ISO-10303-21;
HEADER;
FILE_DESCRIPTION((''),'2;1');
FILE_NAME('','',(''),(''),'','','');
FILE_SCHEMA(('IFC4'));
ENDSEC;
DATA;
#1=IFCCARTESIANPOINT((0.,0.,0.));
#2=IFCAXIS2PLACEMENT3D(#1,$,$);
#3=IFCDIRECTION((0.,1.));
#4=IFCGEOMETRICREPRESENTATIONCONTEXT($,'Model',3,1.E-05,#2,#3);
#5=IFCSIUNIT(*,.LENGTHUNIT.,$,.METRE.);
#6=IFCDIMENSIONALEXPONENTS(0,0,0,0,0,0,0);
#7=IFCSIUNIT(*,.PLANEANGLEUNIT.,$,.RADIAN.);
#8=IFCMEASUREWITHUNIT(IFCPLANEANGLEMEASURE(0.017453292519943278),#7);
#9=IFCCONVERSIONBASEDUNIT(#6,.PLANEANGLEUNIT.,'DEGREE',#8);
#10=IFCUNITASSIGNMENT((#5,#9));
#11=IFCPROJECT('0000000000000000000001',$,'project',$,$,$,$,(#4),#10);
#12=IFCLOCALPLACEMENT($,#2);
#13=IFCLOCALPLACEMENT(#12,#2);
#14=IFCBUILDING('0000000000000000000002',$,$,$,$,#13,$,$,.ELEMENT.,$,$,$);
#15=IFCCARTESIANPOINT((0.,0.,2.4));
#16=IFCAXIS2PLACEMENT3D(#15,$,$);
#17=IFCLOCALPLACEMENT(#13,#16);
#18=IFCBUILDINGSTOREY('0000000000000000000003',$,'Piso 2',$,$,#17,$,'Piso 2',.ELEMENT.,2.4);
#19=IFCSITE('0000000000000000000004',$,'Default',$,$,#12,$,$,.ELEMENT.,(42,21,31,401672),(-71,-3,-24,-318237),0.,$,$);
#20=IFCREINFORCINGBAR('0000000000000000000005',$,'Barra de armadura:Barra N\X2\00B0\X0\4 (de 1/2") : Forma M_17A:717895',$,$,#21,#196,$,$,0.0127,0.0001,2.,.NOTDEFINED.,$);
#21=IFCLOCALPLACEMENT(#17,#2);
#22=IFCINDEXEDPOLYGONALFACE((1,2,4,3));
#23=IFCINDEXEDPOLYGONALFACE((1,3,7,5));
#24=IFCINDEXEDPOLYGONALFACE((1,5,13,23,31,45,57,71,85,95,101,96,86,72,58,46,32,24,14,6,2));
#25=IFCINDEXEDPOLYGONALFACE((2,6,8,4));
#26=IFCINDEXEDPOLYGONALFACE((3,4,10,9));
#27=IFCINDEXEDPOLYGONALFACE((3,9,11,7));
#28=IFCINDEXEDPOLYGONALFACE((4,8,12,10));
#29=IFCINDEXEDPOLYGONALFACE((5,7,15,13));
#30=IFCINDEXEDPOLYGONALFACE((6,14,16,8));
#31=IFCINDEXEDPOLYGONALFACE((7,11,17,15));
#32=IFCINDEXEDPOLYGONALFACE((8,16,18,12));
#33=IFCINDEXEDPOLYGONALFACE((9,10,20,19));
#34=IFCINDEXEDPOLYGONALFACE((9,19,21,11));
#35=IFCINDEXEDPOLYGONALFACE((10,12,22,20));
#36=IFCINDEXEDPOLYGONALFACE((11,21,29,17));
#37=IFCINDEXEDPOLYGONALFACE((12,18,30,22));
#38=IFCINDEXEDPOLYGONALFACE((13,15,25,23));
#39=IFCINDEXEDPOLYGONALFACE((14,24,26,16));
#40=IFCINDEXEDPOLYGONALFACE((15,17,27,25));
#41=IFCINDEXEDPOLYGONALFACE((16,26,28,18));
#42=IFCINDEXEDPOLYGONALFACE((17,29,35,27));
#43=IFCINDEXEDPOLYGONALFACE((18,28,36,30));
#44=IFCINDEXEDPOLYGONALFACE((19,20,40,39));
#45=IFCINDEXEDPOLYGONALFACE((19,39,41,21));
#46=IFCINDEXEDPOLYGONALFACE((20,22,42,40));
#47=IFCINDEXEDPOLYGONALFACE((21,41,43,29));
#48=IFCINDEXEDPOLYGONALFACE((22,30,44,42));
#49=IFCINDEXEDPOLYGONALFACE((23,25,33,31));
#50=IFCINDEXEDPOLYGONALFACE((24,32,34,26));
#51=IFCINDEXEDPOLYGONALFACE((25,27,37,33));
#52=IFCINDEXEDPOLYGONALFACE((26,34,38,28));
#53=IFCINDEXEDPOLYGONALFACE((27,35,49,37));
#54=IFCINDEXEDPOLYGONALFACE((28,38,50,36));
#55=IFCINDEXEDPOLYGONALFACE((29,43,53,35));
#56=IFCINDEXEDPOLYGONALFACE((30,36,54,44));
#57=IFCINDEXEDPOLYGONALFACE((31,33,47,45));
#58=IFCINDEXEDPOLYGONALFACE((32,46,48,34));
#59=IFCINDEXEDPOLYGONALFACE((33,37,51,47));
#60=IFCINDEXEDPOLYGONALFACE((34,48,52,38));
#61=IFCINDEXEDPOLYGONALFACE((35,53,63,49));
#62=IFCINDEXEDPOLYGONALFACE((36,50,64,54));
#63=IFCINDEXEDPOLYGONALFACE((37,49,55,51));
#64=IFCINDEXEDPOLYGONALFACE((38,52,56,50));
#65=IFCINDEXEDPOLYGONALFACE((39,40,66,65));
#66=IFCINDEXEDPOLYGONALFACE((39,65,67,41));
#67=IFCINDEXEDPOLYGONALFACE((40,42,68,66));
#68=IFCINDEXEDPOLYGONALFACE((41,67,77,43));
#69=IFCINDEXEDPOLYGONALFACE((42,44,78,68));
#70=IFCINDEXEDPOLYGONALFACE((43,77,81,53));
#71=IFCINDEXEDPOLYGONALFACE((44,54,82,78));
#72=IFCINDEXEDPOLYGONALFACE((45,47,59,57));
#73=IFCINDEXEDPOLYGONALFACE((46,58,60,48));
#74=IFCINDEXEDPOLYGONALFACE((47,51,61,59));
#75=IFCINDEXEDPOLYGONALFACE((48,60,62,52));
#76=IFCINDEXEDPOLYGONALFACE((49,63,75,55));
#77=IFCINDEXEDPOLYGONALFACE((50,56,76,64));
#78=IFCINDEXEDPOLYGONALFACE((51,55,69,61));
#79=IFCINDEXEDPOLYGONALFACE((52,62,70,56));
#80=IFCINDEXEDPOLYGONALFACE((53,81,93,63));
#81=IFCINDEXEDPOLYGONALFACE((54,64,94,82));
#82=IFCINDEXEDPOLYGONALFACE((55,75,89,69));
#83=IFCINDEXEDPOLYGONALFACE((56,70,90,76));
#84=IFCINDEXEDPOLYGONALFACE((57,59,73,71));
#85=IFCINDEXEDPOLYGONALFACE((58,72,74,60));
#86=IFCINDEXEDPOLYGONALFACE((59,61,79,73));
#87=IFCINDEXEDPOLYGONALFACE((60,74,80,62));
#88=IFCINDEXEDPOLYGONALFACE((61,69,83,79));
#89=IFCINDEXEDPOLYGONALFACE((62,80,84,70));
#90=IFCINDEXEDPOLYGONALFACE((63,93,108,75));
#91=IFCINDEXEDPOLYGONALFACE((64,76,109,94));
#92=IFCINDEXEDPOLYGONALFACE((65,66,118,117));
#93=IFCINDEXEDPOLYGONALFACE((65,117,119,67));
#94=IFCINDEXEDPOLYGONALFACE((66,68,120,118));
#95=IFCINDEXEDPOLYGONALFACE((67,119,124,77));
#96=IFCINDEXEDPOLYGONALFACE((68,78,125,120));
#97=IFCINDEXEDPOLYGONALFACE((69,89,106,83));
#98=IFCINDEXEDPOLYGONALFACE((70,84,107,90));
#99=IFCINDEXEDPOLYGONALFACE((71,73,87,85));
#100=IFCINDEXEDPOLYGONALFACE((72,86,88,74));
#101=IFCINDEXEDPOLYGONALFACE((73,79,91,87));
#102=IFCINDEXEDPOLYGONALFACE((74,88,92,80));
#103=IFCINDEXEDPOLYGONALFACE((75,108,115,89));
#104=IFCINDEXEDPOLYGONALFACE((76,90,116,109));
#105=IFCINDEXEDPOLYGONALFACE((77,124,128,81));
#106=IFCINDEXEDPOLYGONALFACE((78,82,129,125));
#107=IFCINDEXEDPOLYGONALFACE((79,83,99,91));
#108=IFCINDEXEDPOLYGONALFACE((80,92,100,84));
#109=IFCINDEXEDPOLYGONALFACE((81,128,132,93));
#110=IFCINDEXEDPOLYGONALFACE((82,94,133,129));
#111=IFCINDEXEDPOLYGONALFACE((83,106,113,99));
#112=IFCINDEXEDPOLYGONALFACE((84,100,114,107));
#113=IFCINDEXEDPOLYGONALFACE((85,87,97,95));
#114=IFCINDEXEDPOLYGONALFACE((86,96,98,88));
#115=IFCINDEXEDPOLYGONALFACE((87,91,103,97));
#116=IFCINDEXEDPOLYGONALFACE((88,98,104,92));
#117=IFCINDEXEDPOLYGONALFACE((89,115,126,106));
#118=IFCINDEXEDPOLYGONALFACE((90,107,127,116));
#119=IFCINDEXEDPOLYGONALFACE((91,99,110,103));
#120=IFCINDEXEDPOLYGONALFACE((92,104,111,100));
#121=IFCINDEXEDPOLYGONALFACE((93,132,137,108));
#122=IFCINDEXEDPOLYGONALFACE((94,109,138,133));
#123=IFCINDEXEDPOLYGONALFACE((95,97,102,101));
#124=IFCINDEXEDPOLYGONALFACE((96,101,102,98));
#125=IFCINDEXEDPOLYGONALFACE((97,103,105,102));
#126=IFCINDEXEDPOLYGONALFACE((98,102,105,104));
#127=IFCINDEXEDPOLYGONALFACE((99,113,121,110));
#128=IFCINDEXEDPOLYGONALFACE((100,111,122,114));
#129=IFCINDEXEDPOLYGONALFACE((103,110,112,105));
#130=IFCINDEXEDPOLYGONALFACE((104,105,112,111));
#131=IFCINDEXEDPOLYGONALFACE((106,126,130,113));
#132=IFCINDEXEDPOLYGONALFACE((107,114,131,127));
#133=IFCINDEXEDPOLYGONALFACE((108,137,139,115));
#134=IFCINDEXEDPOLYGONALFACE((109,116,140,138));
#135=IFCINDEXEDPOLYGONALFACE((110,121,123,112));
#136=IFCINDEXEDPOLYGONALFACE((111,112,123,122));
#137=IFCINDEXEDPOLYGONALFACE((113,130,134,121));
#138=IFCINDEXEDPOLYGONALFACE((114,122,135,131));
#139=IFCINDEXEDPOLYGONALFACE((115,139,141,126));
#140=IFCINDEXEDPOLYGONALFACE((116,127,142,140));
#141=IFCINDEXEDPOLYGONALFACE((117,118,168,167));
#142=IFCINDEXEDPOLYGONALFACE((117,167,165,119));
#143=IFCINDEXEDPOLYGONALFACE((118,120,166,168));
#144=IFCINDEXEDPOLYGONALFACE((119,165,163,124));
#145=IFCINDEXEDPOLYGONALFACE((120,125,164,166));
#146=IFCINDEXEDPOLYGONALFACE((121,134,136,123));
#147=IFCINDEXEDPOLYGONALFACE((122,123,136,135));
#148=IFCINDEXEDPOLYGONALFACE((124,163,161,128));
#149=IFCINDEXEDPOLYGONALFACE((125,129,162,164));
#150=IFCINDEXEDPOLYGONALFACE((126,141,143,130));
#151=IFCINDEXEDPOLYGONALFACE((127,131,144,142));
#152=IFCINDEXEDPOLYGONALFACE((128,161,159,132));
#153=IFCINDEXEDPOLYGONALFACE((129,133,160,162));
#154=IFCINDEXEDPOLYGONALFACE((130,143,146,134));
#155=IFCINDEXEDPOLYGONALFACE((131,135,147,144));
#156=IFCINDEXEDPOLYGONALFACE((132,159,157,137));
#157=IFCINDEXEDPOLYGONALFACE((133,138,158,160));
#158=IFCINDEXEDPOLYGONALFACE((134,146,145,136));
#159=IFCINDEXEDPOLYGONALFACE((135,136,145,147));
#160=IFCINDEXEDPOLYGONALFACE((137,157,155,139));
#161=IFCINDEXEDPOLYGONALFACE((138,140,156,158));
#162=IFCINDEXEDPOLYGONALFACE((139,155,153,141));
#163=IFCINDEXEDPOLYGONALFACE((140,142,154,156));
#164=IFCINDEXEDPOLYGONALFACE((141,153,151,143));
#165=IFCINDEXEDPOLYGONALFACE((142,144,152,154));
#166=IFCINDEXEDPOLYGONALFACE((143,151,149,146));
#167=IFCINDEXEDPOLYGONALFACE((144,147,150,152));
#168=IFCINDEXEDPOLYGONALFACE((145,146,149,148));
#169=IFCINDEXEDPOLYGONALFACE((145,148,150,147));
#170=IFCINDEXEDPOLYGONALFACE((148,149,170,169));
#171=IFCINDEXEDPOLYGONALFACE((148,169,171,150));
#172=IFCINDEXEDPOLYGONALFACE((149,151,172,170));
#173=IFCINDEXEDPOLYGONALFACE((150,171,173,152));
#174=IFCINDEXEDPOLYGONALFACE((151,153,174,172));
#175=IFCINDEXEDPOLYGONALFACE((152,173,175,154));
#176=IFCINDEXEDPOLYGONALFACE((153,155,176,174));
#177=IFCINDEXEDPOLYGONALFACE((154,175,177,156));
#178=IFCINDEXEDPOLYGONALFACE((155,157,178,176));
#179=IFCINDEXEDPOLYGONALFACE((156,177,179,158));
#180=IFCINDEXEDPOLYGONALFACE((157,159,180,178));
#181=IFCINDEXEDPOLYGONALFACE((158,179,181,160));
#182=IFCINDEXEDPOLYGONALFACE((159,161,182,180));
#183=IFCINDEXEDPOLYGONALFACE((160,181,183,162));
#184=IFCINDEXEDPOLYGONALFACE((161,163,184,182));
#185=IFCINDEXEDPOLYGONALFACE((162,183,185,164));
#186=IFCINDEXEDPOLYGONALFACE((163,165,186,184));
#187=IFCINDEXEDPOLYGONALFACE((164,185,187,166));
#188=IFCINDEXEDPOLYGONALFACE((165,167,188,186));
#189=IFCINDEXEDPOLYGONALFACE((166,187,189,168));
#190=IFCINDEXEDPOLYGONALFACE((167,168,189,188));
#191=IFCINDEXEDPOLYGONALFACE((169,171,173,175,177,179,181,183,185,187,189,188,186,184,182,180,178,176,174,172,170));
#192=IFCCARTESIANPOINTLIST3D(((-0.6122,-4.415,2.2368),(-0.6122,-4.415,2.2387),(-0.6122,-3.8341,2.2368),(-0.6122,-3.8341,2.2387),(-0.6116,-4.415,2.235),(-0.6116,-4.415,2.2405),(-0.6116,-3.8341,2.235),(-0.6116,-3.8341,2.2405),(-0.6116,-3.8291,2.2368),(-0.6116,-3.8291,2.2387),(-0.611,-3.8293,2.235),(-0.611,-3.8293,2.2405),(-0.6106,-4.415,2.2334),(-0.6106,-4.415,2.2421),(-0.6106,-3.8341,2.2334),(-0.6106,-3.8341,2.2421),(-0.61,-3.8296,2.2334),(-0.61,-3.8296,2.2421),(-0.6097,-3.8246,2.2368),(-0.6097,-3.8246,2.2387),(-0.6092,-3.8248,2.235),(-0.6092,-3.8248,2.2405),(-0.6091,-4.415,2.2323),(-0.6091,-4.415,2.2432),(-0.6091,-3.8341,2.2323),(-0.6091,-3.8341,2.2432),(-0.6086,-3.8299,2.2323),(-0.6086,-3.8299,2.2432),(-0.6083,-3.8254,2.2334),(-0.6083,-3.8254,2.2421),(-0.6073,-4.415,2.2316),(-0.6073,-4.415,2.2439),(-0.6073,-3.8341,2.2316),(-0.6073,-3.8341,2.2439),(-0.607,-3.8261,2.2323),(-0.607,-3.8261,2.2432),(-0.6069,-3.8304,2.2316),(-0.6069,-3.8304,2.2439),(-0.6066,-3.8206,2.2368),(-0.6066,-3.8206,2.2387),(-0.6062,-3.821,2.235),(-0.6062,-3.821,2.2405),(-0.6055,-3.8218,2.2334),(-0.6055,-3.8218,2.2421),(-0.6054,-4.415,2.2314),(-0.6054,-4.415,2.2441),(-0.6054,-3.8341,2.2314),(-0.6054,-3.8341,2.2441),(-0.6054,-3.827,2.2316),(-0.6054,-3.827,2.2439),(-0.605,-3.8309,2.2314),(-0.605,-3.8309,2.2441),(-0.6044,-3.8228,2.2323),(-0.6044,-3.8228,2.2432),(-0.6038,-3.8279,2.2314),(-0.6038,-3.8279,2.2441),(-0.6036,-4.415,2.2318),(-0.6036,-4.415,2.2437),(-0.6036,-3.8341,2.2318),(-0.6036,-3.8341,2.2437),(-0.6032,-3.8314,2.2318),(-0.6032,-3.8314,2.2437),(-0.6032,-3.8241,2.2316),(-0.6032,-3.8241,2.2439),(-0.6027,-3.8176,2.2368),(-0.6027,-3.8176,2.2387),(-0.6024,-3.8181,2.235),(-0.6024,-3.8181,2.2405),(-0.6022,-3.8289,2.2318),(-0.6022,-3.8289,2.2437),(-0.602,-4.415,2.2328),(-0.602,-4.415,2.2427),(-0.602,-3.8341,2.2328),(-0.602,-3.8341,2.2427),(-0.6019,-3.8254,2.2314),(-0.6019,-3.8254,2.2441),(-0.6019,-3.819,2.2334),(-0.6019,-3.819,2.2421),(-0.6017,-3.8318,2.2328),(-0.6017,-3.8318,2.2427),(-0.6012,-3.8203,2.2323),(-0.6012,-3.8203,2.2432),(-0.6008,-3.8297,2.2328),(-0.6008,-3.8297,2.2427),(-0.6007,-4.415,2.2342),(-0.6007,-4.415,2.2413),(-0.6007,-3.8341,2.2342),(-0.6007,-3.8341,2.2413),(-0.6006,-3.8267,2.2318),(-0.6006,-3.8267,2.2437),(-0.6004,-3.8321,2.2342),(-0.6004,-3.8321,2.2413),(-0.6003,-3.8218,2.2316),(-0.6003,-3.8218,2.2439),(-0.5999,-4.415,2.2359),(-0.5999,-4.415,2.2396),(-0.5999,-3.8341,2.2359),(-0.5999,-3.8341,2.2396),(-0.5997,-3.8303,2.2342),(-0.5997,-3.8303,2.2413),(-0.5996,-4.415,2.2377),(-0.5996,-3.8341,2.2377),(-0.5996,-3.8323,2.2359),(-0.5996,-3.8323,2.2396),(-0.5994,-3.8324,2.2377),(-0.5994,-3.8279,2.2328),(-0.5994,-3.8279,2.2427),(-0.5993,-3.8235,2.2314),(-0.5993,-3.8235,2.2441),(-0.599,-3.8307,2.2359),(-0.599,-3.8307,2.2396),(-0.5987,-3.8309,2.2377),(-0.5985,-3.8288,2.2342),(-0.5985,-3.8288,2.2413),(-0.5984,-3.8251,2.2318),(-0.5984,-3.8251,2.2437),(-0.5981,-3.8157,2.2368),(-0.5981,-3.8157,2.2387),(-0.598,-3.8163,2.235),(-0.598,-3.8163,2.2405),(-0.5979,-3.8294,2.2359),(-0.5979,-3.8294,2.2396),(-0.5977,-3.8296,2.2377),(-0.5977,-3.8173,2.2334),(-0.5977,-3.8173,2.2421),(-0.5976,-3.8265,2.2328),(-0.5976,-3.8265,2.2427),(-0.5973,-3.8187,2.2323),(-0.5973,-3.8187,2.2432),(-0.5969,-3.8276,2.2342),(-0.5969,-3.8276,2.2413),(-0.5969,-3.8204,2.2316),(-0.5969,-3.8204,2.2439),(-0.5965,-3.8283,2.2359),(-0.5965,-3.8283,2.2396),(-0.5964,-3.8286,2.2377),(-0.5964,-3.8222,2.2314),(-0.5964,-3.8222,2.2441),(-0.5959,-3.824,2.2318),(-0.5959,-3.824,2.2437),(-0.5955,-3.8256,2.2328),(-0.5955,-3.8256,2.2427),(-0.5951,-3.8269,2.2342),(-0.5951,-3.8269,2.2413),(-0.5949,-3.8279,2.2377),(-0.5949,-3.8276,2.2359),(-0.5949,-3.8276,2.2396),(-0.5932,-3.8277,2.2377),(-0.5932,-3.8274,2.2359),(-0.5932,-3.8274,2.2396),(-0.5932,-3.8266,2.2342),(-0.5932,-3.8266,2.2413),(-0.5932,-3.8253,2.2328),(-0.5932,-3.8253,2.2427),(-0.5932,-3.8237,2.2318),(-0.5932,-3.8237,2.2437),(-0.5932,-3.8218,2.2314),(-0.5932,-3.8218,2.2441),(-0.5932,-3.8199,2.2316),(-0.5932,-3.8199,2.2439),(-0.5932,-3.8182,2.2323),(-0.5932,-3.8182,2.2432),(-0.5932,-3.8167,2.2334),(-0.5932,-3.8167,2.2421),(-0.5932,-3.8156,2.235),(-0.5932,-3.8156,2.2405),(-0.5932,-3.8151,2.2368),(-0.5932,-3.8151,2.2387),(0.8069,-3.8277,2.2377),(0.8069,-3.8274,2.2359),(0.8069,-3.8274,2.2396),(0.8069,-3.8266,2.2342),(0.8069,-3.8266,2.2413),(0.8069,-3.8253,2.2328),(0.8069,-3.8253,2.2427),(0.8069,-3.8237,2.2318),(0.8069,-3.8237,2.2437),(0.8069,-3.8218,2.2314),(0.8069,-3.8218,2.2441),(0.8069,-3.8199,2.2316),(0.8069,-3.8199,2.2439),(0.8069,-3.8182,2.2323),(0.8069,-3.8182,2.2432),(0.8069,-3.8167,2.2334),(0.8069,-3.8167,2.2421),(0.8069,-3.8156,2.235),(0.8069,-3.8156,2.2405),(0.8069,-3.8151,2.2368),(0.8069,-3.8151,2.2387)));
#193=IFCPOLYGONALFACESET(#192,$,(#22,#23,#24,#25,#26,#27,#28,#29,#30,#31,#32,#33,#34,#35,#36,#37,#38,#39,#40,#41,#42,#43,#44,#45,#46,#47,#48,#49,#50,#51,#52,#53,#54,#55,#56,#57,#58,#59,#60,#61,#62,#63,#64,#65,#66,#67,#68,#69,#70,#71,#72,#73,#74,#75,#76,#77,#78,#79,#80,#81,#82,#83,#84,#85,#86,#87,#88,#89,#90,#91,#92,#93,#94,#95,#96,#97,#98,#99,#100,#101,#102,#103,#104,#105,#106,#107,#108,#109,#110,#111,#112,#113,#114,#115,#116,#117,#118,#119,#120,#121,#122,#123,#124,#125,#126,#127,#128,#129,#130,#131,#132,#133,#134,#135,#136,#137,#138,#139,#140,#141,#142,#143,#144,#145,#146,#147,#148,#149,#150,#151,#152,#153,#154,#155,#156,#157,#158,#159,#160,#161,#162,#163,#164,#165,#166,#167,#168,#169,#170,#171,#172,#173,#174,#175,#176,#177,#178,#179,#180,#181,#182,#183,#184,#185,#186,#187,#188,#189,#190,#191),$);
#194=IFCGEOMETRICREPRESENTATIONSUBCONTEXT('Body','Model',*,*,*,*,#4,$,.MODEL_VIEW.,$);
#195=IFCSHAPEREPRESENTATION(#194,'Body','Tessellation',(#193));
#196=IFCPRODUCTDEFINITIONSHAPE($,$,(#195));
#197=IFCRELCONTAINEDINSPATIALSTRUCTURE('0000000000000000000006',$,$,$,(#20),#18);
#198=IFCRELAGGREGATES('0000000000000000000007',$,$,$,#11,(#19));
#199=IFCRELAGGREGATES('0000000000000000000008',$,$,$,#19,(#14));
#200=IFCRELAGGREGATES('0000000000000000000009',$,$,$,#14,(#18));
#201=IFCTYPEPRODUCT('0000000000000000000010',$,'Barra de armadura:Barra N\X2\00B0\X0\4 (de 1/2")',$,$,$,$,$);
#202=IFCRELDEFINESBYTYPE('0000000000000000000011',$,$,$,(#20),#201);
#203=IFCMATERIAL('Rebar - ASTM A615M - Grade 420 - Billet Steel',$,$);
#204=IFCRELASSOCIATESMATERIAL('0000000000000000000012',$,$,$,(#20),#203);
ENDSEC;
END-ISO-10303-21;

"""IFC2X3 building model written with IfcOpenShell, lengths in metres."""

from ifc_helpers import new_model, entity, si_unit, converted_unit, direction, frame, origin, place, context, subcontext, project, spatial, material, type_object, element, save


model = new_model("IFC2X3")

# Units and contexts
model_context = context("Model", 3, precision=1e-05, world=origin(), true_north=direction((0.0, 1.0)))
body_context = subcontext(model_context, "Body", "Model", "MODEL_VIEW")
ifc_project = project(units=[si_unit("LENGTHUNIT", "METRE"), converted_unit("PLANEANGLEUNIT", "DEGREE", entity("IfcPlaneAngleMeasure", 0.017453292519943278), si_unit("PLANEANGLEUNIT", "RADIAN"), dimensions=[0, 0, 0, 0, 0, 0, 0])], contexts=[model_context])

# Site, building, storey
site_placement = place(None, origin())
site = spatial("IfcSite", under=ifc_project, at=site_placement, Name="Default", CompositionType="ELEMENT", RefLatitude=(42, 21, 31, 401672), RefLongitude=(-71, -3, -24, -318237), RefElevation=0.0)
building_placement = place(site_placement, origin())
building = spatial("IfcBuilding", under=site, at=building_placement, CompositionType="ELEMENT")
storey_placement = place(building_placement, frame((0.0, 0.0, 2.4)))
storey = spatial("IfcBuildingStorey", under=building, at=storey_placement, Name="Piso 2", LongName="Piso 2", CompositionType="ELEMENT", Elevation=2.4)

# Reinforcing bar
ifc_material_1 = material(Name="Rebar - ASTM A615M - Grade 420 - Billet Steel")
type_product_1 = type_object("IfcTypeProduct", Name="Barra de armadura:Barra N°4 (de 1/2\")")
reinforcing_bar_1_placement = place(storey_placement, origin())
element("IfcReinforcingBar", 1, at=reinforcing_bar_1_placement, inside=storey, type_object=type_product_1, material=ifc_material_1, Name="Barra de armadura:Barra N°4 (de 1/2\") : Forma M_17A:717895", BarLength=2.0, BarRole="NOTDEFINED", CrossSectionArea=0.0001, NominalDiameter=0.0127, context=body_context, shape_type="AdvancedSweptSolid", body=[
    entity("IfcSweptDiskSolid", entity("IfcCompositeCurve", [entity("IfcCompositeCurveSegment", "CONTINUOUS", True, entity("IfcPolyline", [entity("IfcCartesianPoint", [0.8069, -3.8214, 2.2377]), entity("IfcCartesianPoint", [-0.5932, -3.8214, 2.2377])])), entity("IfcCompositeCurveSegment", "CONTINUOUS", True, entity("IfcTrimmedCurve", entity("IfcCircle", entity("IfcAxis2Placement3D", entity("IfcCartesianPoint", [-0.5932, -3.8341, 2.2377]), entity("IfcDirection", [0.0, 0.0, 1.0]), entity("IfcDirection", [-1.0, 0.0, 0.0])), 0.0127), [entity("IfcParameterValue", 270.0)], [entity("IfcParameterValue", 360.0)], True, "PARAMETER")), entity("IfcCompositeCurveSegment", "CONTINUOUS", True, entity("IfcPolyline", [entity("IfcCartesianPoint", [-0.6059, -3.8341, 2.2377]), entity("IfcCartesianPoint", [-0.6059, -4.415, 2.2377])]))], False), 0.0063, None, 0.0, 92.0),
])

save(model, "model.ifc")
